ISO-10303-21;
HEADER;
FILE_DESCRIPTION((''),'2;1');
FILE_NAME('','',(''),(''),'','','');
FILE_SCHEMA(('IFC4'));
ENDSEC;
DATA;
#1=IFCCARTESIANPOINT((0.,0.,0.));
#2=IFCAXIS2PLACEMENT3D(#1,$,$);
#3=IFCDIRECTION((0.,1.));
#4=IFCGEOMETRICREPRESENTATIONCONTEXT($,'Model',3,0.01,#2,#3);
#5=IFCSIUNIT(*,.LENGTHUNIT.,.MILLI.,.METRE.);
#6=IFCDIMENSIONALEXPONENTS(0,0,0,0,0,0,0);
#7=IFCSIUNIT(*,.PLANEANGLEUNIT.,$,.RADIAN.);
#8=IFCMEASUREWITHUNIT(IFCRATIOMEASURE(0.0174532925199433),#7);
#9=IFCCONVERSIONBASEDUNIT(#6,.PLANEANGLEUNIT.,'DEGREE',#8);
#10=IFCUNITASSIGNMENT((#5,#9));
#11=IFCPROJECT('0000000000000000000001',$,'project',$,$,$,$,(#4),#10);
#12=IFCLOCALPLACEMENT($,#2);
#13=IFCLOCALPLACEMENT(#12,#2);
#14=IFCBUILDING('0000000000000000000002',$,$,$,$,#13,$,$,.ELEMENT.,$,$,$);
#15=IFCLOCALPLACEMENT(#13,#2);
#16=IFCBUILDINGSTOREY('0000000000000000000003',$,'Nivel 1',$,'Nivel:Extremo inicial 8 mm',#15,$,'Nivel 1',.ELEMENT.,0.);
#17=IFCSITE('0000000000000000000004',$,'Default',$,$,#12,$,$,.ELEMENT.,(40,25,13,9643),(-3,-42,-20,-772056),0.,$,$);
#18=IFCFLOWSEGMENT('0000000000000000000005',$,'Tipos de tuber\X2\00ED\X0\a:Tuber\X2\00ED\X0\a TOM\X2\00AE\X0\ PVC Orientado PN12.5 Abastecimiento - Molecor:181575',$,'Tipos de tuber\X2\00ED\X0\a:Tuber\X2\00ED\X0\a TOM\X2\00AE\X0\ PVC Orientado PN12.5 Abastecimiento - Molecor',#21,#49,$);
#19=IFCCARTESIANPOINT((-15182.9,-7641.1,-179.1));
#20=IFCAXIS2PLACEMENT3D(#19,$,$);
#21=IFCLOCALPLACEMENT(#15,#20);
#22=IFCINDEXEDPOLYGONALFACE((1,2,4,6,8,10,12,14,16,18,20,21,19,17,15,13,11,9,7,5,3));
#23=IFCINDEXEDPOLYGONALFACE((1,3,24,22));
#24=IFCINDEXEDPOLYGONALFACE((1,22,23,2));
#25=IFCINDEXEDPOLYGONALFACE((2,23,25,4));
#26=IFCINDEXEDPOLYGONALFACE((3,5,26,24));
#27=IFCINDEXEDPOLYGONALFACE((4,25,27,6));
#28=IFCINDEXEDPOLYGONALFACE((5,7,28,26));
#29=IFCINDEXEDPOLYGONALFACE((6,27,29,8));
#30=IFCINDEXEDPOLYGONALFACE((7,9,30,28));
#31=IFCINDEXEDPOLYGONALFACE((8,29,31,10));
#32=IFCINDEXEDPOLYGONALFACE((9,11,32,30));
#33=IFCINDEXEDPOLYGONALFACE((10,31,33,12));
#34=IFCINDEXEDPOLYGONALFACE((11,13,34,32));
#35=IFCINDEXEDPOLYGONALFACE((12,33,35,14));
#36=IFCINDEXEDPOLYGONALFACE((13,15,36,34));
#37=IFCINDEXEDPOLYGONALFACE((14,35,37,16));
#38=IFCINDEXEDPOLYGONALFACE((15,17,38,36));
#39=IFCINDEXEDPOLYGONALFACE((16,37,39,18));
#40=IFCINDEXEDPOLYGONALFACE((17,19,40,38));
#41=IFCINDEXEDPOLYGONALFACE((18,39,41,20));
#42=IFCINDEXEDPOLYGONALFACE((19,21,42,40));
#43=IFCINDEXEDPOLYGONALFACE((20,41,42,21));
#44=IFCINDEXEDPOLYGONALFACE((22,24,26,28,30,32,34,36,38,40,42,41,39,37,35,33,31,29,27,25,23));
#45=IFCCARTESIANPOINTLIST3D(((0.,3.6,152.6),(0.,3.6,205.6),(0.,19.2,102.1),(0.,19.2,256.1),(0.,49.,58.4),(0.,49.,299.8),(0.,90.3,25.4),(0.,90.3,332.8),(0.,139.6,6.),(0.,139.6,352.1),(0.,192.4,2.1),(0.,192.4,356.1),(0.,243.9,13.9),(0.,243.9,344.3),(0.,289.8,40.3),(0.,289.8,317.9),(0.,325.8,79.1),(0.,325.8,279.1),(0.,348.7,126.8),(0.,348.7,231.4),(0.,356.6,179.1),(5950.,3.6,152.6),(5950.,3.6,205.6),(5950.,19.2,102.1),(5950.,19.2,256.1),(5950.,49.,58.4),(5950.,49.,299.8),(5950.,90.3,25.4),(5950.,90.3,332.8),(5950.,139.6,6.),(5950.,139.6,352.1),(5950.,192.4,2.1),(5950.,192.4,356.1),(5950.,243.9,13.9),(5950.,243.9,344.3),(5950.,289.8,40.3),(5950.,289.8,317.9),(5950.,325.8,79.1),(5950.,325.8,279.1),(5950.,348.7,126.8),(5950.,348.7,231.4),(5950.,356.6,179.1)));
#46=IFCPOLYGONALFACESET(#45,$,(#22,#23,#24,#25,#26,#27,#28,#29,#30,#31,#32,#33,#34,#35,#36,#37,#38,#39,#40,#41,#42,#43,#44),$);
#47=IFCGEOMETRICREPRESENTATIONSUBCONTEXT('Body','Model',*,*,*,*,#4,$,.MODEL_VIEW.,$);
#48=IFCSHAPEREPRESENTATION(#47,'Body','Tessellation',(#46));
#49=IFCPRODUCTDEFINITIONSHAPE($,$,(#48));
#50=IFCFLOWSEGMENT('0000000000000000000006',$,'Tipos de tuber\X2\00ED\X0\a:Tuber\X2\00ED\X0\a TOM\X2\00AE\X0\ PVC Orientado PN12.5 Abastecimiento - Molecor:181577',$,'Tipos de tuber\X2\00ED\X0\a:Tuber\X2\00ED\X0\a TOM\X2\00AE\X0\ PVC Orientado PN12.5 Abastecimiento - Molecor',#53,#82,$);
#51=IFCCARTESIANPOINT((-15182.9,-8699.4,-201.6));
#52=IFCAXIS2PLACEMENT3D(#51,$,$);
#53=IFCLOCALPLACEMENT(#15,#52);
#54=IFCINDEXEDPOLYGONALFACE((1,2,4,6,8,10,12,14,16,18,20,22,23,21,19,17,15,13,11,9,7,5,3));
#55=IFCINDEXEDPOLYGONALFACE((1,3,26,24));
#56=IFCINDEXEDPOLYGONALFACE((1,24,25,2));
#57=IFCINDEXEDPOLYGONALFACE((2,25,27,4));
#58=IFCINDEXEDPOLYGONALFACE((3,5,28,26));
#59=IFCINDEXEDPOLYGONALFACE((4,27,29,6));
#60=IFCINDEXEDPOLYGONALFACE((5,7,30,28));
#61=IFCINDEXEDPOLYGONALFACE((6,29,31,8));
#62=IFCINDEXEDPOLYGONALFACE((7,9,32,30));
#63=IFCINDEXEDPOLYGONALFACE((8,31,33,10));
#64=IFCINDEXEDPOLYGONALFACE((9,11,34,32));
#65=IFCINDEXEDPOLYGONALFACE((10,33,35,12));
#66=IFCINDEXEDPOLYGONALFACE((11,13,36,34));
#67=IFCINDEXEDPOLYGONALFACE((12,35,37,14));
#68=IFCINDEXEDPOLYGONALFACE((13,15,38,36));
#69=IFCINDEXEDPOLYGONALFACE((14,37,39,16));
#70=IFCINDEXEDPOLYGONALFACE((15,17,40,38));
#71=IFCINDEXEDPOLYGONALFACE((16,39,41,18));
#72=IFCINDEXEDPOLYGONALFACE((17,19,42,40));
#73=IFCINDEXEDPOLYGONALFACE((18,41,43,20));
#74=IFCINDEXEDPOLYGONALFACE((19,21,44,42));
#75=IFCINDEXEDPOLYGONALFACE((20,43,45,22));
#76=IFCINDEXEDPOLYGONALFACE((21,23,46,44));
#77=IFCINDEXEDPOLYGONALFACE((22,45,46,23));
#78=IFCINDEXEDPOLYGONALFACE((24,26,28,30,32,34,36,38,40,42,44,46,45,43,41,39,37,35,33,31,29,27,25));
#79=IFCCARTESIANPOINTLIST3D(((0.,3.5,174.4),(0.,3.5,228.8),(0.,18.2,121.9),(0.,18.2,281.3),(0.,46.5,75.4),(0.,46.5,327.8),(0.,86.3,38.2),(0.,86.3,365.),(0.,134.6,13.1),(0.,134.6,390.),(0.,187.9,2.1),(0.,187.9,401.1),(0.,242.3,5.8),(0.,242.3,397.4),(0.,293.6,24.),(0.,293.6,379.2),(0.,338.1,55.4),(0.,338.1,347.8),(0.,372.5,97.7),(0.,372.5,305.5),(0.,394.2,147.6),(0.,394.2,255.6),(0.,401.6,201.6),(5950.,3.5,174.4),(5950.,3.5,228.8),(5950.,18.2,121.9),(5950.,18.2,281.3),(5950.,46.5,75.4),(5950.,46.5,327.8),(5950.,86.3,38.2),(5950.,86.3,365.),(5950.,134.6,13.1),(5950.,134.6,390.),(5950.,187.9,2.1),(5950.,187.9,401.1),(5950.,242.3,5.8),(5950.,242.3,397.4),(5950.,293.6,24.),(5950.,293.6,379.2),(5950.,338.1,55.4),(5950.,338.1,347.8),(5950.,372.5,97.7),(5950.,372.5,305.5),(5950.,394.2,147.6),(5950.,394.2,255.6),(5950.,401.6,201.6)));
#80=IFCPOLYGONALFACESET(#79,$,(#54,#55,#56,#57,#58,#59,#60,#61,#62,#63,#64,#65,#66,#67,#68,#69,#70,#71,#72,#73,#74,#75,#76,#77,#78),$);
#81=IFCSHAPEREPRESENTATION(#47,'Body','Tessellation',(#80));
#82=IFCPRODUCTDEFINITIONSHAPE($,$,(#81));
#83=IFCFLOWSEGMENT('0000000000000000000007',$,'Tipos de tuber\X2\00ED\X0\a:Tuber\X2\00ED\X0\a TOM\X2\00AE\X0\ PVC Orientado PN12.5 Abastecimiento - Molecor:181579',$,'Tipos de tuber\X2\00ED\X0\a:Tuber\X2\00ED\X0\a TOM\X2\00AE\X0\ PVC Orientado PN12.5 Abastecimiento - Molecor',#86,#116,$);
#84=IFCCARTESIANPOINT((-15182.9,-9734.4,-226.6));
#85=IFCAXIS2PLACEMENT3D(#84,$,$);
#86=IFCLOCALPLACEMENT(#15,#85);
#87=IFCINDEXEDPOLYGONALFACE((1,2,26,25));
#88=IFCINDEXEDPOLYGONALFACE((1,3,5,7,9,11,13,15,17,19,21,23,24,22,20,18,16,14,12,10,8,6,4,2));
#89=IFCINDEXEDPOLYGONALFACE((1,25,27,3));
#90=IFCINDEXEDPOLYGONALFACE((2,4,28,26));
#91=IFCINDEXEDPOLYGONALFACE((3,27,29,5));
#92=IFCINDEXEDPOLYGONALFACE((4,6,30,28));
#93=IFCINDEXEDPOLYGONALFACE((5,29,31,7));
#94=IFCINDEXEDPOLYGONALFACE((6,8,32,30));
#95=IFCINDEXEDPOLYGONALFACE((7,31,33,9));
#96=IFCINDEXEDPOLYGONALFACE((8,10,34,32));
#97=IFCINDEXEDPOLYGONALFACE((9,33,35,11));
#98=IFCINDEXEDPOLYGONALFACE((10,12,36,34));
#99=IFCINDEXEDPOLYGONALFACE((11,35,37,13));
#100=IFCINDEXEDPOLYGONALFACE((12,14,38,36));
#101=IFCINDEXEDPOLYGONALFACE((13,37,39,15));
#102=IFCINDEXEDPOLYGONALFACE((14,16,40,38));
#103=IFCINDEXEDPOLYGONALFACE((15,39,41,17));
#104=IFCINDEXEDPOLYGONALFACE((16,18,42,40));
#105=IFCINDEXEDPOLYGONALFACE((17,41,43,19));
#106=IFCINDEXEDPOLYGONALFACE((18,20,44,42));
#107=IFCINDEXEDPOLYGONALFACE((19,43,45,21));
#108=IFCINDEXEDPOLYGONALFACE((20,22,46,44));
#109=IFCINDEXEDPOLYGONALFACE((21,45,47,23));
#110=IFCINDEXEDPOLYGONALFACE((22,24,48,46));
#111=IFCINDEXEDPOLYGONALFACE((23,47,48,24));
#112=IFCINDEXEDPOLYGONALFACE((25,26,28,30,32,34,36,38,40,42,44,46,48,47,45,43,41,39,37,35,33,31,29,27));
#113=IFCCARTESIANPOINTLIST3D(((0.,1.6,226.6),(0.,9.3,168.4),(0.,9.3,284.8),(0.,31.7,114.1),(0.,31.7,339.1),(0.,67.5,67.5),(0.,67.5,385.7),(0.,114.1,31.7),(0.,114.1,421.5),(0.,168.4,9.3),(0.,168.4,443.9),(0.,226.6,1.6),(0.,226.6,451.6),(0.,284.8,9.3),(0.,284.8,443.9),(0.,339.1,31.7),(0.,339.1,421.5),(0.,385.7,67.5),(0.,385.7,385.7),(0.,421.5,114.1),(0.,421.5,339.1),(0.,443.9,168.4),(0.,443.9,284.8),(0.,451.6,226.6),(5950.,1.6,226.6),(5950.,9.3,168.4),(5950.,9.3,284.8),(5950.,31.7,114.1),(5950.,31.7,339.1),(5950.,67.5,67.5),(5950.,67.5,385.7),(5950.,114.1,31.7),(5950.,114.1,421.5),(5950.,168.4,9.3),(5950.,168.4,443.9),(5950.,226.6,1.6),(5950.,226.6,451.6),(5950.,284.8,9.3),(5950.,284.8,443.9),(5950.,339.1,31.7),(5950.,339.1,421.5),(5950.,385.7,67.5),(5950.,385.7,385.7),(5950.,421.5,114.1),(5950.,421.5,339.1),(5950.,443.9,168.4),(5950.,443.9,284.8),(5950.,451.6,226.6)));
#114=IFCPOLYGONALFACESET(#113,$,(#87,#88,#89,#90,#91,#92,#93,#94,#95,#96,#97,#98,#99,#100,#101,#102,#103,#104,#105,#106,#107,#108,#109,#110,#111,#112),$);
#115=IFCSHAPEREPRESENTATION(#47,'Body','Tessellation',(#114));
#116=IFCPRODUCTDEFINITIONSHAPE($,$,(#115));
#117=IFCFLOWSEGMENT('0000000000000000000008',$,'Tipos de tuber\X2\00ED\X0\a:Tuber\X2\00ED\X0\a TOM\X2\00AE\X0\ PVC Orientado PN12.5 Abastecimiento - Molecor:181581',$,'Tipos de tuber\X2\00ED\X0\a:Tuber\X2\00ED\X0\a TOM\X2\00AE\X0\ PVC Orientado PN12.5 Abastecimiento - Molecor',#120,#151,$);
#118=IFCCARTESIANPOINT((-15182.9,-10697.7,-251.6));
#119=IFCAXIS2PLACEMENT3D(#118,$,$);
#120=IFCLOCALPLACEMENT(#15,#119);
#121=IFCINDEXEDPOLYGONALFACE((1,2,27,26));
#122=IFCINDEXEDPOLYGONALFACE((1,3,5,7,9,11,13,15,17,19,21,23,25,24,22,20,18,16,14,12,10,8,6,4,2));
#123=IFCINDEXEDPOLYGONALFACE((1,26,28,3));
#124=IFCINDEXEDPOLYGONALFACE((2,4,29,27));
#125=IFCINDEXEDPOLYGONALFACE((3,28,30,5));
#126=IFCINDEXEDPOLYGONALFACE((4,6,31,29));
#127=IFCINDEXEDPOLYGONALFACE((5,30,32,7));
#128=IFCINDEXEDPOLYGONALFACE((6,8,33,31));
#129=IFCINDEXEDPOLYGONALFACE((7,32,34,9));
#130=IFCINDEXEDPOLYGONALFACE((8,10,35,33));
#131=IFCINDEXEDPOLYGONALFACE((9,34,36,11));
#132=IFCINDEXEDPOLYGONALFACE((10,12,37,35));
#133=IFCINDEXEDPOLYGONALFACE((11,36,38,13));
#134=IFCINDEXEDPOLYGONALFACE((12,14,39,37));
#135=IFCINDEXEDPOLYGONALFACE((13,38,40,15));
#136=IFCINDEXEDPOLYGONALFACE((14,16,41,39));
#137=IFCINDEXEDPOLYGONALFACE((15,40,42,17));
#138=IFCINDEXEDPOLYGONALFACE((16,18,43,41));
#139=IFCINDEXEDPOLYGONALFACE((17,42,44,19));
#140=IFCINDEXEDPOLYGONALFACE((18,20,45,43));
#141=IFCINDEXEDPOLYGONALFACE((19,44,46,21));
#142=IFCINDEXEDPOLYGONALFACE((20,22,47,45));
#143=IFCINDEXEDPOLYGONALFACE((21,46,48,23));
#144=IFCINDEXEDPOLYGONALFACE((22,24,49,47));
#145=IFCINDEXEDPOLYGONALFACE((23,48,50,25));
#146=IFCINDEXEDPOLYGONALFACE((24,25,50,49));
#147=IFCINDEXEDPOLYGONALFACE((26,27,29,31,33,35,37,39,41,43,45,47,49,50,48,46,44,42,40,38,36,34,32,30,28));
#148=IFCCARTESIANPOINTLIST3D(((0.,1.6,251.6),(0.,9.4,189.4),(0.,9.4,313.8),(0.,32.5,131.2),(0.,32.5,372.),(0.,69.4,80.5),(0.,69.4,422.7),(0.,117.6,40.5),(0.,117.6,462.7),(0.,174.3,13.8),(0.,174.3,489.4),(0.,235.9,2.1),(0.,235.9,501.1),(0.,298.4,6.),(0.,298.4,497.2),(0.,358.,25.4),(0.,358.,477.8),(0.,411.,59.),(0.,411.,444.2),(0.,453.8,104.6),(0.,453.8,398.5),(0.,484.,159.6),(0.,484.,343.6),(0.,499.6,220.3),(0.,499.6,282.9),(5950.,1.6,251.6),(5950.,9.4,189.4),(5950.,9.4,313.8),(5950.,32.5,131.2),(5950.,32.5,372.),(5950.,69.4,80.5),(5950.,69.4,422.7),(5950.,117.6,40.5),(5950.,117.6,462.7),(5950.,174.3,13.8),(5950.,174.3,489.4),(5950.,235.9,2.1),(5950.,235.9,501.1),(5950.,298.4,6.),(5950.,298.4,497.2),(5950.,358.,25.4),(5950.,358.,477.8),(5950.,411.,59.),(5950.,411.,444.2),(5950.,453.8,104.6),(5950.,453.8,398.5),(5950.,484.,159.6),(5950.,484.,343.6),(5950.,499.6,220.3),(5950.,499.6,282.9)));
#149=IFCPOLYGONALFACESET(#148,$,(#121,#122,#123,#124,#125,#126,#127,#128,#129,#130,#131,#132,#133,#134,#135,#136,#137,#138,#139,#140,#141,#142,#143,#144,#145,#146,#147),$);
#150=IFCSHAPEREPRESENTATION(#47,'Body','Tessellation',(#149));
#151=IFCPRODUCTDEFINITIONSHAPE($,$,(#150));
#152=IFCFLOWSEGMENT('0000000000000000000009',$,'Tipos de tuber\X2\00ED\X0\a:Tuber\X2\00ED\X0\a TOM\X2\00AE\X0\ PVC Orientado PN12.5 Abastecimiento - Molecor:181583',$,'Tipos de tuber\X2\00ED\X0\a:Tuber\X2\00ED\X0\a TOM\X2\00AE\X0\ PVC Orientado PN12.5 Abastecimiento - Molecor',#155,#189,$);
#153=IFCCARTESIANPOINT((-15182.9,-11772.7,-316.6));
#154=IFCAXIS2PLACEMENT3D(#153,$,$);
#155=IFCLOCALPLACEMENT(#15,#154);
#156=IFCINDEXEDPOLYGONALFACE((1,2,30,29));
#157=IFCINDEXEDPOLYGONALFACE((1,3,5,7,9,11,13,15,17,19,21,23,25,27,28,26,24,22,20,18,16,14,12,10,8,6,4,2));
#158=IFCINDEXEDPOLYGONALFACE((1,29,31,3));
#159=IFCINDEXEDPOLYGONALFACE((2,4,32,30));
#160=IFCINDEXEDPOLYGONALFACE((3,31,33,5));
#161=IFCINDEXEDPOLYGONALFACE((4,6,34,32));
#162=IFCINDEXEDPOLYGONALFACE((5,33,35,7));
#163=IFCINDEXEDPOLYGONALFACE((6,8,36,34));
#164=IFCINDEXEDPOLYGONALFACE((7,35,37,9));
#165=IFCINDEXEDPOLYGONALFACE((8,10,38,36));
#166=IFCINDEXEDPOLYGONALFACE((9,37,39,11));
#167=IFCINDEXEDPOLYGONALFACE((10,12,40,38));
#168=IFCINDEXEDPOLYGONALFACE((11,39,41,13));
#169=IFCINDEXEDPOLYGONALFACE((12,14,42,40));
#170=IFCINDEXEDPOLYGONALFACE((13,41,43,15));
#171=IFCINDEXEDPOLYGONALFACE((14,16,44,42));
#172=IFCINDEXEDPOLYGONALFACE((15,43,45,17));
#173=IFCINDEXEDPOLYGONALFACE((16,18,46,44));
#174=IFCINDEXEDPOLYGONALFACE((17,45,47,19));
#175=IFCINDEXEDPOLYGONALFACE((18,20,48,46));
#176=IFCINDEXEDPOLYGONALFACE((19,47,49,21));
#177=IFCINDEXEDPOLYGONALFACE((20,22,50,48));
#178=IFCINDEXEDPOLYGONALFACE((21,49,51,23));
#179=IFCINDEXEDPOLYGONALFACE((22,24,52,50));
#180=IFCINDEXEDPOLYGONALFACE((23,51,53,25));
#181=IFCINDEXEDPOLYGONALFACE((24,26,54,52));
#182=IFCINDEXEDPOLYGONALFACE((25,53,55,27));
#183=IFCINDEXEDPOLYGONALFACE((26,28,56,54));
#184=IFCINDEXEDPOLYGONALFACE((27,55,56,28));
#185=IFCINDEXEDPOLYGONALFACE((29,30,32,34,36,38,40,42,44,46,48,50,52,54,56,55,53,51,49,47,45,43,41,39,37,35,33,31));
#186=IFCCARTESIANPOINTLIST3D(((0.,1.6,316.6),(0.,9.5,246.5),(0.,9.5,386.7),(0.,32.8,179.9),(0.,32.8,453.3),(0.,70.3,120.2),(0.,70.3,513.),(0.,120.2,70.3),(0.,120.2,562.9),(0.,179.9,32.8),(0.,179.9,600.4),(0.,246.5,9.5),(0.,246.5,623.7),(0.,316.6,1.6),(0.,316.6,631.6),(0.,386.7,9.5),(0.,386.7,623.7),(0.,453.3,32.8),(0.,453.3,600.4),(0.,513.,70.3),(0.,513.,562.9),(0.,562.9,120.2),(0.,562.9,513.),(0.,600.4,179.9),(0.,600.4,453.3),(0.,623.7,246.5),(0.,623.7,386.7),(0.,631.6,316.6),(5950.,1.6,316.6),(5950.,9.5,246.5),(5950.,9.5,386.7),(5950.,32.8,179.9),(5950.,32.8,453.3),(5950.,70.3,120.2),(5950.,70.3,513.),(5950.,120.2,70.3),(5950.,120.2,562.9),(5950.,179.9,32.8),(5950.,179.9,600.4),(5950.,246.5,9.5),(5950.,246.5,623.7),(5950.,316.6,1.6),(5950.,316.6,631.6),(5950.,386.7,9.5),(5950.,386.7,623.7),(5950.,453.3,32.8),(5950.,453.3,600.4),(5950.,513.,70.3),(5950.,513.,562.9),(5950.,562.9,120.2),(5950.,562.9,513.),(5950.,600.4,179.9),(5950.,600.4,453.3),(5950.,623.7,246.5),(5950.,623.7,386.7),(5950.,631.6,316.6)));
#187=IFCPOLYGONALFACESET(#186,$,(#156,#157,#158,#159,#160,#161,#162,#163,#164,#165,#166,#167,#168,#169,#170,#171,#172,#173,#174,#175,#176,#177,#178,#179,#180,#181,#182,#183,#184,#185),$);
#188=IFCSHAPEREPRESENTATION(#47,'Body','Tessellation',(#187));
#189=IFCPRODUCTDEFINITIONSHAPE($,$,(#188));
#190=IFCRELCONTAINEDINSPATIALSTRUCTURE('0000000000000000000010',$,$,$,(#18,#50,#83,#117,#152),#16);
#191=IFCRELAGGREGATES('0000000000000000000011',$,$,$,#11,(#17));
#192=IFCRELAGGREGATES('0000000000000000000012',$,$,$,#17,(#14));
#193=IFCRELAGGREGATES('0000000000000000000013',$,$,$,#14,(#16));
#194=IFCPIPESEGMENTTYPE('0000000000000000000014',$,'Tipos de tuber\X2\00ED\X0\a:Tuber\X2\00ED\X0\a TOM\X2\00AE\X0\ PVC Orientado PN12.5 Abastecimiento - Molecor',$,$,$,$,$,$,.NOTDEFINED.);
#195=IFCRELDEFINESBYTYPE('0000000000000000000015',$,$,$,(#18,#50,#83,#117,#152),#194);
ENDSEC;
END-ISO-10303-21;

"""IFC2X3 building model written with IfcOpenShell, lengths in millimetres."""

from ifc_helpers import new_model, entity, si_unit, converted_unit, direction, frame, frame_2d, origin, place, context, subcontext, project, spatial, circle, extrude, type_object, element, save


model = new_model("IFC2X3")

# Units and contexts
model_context = context("Model", 3, precision=0.01, world=origin(), true_north=direction((0.0, 1.0)))
body_context = subcontext(model_context, "Body", "Model", "MODEL_VIEW")
ifc_project = project(units=[si_unit("LENGTHUNIT", "METRE", prefix="MILLI"), converted_unit("PLANEANGLEUNIT", "DEGREE", entity("IfcRatioMeasure", 0.0174532925199433), si_unit("PLANEANGLEUNIT", "RADIAN"), dimensions=[0, 0, 0, 0, 0, 0, 0])], contexts=[model_context])

# Site, building, storey
site_placement = place(None, origin())
site = spatial("IfcSite", under=ifc_project, at=site_placement, Name="Default", CompositionType="ELEMENT", RefLatitude=(40, 25, 13, 9643), RefLongitude=(-3, -42, -20, -772056), RefElevation=0.0)
building_placement = place(site_placement, origin())
building = spatial("IfcBuilding", under=site, at=building_placement, CompositionType="ELEMENT")
storey_placement = place(building_placement, origin())
storey = spatial("IfcBuildingStorey", under=building, at=storey_placement, Name="Nivel 1", ObjectType="Nivel:Extremo inicial 8 mm", LongName="Nivel 1", CompositionType="ELEMENT", Elevation=0.0)

# Flow segments
pipe_segment_type = type_object("IfcPipeSegmentType", Name="Tipos de tubería:Tubería TOM® PVC Orientado PN12.5 Abastecimiento - Molecor", PredefinedType="NOTDEFINED")
flow_segment_1_placement = place(storey_placement, frame((-15182.9, -7641.1, -179.1)))
element("IfcFlowSegment", 1, at=flow_segment_1_placement, inside=storey, type_object=pipe_segment_type, Name="Tipos de tubería:Tubería TOM® PVC Orientado PN12.5 Abastecimiento - Molecor:181575", ObjectType="Tipos de tubería:Tubería TOM® PVC Orientado PN12.5 Abastecimiento - Molecor", context=body_context, shape_type="SweptSolid", body=[
    extrude(circle(Radius=177.5, at=frame_2d((0.0, 0.0), x_axis=(1.0, 0.0))), frame((0.0, 179.1, 179.1), z_axis=(1.0, 0.0, 0.0), x_axis=(0.0, 1.0, 0.0)), (0.0, 0.0, 1.0), 5950.0),
])
flow_segment_2_placement = place(storey_placement, frame((-15182.9, -8699.4, -201.6)))
element("IfcFlowSegment", 2, at=flow_segment_2_placement, inside=storey, type_object=pipe_segment_type, Name="Tipos de tubería:Tubería TOM® PVC Orientado PN12.5 Abastecimiento - Molecor:181577", ObjectType="Tipos de tubería:Tubería TOM® PVC Orientado PN12.5 Abastecimiento - Molecor", context=body_context, shape_type="SweptSolid", body=[
    extrude(circle(Radius=200.0, at=frame_2d((0.0, 0.0), x_axis=(1.0, 0.0))), frame((0.0, 201.6, 201.6), z_axis=(1.0, 0.0, 0.0), x_axis=(0.0, 1.0, 0.0)), (0.0, 0.0, 1.0), 5950.0),
])
flow_segment_3_placement = place(storey_placement, frame((-15182.9, -9734.4, -226.6)))
element("IfcFlowSegment", 3, at=flow_segment_3_placement, inside=storey, type_object=pipe_segment_type, Name="Tipos de tubería:Tubería TOM® PVC Orientado PN12.5 Abastecimiento - Molecor:181579", ObjectType="Tipos de tubería:Tubería TOM® PVC Orientado PN12.5 Abastecimiento - Molecor", context=body_context, shape_type="SweptSolid", body=[
    extrude(circle(Radius=225.0, at=frame_2d((0.0, 0.0), x_axis=(1.0, 0.0))), frame((0.0, 226.6, 226.6), z_axis=(1.0, 0.0, 0.0), x_axis=(0.0, -1.0, 0.0)), (0.0, 0.0, 1.0), 5950.0),
])
flow_segment_4_placement = place(storey_placement, frame((-15182.9, -10697.7, -251.6)))
element("IfcFlowSegment", 4, at=flow_segment_4_placement, inside=storey, type_object=pipe_segment_type, Name="Tipos de tubería:Tubería TOM® PVC Orientado PN12.5 Abastecimiento - Molecor:181581", ObjectType="Tipos de tubería:Tubería TOM® PVC Orientado PN12.5 Abastecimiento - Molecor", context=body_context, shape_type="SweptSolid", body=[
    extrude(circle(Radius=250.0, at=frame_2d((0.0, 0.0), x_axis=(1.0, 0.0))), frame((0.0, 251.6, 251.6), z_axis=(1.0, 0.0, 0.0), x_axis=(0.0, -1.0, 0.0)), (0.0, 0.0, 1.0), 5950.0),
])
flow_segment_5_placement = place(storey_placement, frame((-15182.9, -11772.7, -316.6)))
element("IfcFlowSegment", 5, at=flow_segment_5_placement, inside=storey, type_object=pipe_segment_type, Name="Tipos de tubería:Tubería TOM® PVC Orientado PN12.5 Abastecimiento - Molecor:181583", ObjectType="Tipos de tubería:Tubería TOM® PVC Orientado PN12.5 Abastecimiento - Molecor", context=body_context, shape_type="SweptSolid", body=[
    extrude(circle(Radius=315.0, at=frame_2d((0.0, 0.0), x_axis=(1.0, 0.0))), frame((0.0, 316.6, 316.6), z_axis=(1.0, 0.0, 0.0), x_axis=(0.0, -1.0, 0.0)), (0.0, 0.0, 1.0), 5950.0),
])

save(model, "model.ifc")
